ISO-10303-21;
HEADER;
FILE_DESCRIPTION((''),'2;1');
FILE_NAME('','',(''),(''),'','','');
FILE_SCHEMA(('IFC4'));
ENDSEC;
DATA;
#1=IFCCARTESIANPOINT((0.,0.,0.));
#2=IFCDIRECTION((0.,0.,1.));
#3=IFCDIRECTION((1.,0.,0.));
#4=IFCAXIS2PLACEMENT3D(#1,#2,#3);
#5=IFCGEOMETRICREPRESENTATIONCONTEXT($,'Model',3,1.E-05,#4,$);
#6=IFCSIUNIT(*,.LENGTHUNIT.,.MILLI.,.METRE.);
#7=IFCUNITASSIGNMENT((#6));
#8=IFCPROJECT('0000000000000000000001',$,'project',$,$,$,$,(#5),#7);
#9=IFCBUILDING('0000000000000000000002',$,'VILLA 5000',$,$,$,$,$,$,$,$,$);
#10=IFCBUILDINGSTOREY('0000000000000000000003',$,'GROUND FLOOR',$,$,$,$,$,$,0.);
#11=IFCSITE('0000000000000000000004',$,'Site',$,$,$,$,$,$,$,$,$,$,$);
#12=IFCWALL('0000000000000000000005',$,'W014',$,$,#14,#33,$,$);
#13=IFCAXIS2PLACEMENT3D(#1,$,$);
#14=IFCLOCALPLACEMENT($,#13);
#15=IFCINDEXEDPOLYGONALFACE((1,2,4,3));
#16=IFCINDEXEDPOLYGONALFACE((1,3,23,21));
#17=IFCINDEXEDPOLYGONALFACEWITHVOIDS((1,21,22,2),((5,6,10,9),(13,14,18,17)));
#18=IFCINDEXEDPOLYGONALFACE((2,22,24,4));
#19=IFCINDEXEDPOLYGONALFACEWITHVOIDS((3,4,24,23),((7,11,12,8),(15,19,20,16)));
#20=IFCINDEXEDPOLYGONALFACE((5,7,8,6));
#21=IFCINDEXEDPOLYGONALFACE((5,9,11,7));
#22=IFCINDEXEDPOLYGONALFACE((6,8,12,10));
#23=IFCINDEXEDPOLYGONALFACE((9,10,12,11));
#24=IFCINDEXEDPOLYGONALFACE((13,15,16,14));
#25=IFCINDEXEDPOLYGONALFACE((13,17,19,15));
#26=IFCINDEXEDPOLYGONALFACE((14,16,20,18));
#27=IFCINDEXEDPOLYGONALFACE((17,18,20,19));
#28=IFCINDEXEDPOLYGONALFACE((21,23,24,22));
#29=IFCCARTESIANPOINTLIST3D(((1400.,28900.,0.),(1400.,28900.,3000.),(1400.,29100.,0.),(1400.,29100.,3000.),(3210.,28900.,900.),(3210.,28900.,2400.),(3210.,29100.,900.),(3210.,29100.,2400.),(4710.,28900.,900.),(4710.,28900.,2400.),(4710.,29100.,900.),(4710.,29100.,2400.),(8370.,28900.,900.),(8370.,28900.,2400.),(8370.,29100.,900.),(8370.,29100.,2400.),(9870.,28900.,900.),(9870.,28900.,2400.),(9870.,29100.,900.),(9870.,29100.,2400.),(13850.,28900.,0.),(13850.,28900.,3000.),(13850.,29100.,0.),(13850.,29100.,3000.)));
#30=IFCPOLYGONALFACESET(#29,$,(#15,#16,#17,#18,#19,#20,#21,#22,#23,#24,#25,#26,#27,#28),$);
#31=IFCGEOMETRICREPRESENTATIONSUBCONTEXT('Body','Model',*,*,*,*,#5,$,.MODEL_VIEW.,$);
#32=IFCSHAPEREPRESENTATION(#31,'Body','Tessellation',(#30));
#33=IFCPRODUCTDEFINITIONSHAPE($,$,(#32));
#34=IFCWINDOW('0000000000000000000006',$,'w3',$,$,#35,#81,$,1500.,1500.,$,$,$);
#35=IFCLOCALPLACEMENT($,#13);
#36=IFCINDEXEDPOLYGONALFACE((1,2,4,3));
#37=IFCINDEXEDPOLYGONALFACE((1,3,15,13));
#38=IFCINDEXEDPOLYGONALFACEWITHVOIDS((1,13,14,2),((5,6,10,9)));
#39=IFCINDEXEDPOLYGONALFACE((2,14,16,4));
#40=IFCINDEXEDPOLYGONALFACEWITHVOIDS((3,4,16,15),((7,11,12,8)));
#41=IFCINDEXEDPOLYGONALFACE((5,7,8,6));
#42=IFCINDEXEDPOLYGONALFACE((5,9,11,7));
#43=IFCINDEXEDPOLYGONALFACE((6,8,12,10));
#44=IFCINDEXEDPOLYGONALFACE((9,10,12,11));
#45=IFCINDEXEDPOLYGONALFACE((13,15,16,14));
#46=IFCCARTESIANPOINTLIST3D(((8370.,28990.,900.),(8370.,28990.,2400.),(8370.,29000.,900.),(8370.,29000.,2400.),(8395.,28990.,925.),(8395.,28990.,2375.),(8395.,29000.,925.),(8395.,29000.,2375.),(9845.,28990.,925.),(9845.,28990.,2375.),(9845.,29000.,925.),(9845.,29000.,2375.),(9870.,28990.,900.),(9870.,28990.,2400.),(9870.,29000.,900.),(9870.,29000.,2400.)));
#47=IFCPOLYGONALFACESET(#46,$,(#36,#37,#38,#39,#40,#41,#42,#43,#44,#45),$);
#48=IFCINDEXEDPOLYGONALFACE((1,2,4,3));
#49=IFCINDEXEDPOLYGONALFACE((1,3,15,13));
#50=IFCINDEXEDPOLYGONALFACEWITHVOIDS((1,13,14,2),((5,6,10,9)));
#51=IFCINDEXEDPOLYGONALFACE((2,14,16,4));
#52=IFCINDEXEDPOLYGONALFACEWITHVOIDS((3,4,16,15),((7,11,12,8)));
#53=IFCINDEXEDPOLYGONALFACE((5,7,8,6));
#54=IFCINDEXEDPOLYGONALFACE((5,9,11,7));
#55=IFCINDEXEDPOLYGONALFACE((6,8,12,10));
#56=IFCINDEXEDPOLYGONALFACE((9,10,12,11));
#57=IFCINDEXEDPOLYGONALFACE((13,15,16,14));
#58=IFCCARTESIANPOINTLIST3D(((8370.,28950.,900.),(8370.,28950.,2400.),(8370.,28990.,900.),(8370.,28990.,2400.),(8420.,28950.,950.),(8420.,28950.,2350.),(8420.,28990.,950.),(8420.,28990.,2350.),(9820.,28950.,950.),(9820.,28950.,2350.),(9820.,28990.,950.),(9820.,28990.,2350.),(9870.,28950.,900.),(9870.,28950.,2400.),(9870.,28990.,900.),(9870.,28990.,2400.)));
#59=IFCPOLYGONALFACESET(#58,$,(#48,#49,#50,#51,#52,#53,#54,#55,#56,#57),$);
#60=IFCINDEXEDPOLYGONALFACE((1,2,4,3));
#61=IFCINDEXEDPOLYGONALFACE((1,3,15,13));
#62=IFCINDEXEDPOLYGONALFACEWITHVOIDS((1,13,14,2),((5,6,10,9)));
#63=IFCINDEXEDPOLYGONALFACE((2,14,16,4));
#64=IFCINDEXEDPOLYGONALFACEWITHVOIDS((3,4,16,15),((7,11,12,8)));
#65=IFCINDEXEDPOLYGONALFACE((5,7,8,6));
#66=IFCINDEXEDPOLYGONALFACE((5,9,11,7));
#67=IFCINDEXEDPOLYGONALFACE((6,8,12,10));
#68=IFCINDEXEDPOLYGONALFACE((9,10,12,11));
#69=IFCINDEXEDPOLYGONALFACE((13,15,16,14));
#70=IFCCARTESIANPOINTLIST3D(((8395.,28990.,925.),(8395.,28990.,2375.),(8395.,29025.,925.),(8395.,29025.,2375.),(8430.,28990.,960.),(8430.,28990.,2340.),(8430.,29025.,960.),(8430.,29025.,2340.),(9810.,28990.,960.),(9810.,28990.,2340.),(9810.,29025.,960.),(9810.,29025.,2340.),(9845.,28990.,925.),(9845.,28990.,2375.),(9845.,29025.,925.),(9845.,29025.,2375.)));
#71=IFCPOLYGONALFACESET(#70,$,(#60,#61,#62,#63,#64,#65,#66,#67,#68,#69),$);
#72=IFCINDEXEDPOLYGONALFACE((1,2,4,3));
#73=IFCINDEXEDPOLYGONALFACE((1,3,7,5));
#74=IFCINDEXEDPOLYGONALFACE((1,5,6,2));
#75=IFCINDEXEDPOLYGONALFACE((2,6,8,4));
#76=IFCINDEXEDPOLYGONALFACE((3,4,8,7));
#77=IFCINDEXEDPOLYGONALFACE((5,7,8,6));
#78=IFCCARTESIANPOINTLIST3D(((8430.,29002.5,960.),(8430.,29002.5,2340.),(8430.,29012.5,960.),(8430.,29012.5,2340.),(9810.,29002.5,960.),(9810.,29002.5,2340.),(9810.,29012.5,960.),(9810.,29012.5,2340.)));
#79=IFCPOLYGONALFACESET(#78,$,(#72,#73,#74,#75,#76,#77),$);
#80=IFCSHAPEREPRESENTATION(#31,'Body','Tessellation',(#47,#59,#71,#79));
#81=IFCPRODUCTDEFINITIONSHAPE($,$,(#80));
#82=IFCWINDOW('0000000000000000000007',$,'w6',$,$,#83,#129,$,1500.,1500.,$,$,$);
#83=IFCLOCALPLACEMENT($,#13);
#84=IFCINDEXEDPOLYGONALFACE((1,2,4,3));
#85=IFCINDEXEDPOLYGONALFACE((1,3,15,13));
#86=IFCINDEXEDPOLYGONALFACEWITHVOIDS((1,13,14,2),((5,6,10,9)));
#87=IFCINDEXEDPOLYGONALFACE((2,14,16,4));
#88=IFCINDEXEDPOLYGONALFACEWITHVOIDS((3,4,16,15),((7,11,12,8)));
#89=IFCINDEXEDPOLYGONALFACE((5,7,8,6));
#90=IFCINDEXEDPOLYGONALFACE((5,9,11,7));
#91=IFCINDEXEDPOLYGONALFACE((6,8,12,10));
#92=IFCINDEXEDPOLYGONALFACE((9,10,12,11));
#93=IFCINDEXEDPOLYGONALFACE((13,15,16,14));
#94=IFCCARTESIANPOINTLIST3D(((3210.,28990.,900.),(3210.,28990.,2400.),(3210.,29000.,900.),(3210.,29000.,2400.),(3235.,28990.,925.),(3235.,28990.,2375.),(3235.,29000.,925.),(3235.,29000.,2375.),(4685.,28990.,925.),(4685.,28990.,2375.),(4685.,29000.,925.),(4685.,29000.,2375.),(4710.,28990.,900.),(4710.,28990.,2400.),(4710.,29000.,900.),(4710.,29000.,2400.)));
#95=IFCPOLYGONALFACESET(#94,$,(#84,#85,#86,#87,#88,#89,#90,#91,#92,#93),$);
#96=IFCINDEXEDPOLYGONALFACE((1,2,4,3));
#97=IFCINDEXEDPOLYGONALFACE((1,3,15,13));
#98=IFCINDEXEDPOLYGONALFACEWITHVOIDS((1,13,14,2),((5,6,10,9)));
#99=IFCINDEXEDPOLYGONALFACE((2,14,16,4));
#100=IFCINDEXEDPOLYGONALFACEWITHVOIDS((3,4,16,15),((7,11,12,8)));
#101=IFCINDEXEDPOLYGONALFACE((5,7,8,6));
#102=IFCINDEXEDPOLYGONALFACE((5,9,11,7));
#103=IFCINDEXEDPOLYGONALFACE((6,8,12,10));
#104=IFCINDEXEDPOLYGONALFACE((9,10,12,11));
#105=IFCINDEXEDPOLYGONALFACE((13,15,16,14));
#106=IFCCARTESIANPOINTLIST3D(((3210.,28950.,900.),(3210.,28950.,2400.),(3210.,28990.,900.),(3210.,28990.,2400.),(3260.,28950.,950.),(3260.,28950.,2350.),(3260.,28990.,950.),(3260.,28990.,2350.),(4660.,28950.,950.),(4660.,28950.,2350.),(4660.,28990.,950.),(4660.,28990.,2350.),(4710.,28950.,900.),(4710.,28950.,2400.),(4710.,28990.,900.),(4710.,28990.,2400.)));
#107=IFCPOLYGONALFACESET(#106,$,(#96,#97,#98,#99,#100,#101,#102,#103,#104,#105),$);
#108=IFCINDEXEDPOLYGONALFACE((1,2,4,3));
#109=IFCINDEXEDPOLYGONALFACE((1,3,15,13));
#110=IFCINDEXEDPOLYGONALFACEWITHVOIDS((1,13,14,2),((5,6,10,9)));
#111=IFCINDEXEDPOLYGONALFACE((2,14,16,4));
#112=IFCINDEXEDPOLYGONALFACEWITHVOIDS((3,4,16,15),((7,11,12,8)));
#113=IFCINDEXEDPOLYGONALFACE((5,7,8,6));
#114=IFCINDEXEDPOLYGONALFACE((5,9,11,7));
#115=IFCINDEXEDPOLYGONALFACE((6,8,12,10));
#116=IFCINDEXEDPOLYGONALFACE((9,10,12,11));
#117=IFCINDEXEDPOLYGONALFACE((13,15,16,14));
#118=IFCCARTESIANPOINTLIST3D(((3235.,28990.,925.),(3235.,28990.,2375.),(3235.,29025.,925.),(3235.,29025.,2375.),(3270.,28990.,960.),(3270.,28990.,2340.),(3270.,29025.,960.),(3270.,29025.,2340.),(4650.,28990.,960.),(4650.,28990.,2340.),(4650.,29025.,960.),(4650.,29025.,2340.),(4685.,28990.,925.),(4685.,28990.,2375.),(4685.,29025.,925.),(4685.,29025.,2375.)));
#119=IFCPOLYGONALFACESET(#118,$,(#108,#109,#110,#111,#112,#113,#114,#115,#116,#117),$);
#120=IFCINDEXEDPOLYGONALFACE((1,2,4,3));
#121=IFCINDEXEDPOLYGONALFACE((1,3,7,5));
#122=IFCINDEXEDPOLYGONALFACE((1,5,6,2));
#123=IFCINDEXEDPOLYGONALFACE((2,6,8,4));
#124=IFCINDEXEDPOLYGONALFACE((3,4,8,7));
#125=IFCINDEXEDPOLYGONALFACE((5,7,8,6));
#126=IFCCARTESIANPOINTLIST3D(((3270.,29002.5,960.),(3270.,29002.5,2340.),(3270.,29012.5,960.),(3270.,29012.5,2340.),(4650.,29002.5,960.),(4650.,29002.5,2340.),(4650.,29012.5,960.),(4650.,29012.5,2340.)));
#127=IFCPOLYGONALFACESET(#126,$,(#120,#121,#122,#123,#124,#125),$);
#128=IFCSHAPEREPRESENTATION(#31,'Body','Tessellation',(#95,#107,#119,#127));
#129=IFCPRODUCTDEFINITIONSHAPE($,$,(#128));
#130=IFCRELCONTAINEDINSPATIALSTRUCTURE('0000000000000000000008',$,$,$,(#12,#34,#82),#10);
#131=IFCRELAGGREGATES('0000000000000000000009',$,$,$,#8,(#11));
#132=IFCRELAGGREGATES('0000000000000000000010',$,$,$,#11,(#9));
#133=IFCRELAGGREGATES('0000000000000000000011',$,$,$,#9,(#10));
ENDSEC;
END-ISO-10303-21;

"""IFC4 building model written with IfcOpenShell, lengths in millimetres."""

from ifc_helpers import new_model, si_unit, frame, origin_with_axes, place, context, subcontext, project, spatial, line, indexed_curve, outline, extrude, element, fill, save


model = new_model("IFC4")

# Units and contexts
model_context = context("Model", 3, precision=1e-05, world=origin_with_axes())
body_context = subcontext(model_context, "Body", "Model", "MODEL_VIEW")
ifc_project = project(units=[si_unit("LENGTHUNIT", "METRE", prefix="MILLI")], contexts=[model_context])

# Site, building, storey
site = spatial("IfcSite", under=ifc_project, Name="Site")
building = spatial("IfcBuilding", under=site, Name="VILLA 5000")
storey = spatial("IfcBuildingStorey", under=building, Name="GROUND FLOOR", Elevation=0.0)

# Wall, openings, windows
wall_1_placement = place(None, frame((1400.0, 29000.0, 0.0), z_axis=(0.0, 0.0, 1.0), x_axis=(1.0, 0.0, 0.0)))
wall_1 = element("IfcWall", 1, at=wall_1_placement, inside=storey, Name="W014", context=body_context, shape_type="SweptSolid", body=[
    extrude(outline(indexed_curve([(0.0, 0.0), (0.0, 200.0), (12450.0, 200.0), (12450.0, 0.0), (0.0, 0.0)], self_intersect=False)), frame((0.0, -100.0, 0.0), z_axis=(0.0, 0.0, 1.0), x_axis=(1.0, 0.0, 0.0)), (0.0, 0.0, 1.0), 3000.0),
])
opening_1_placement = place(wall_1_placement, frame((6970.0, 0.0, 900.0), z_axis=(0.0, 0.0, 1.0), x_axis=(1.0, 0.0, 0.0)))
opening_1 = element("IfcOpeningElement", 2, at=opening_1_placement, cuts=wall_1, context=body_context, shape_type="SweptSolid", body=[
    extrude(outline(indexed_curve([(0.0, 0.0), (0.0, 300.0), (1500.0, 300.0), (1500.0, 0.0), (0.0, 0.0)], self_intersect=False)), frame((0.0, -150.0, 0.0), z_axis=(0.0, 0.0, 1.0), x_axis=(1.0, 0.0, 0.0)), (0.0, 0.0, 1.0), 1500.0),
])
opening_2_placement = place(wall_1_placement, frame((1810.0, 0.0, 900.0), z_axis=(0.0, 0.0, 1.0), x_axis=(1.0, 0.0, 0.0)))
opening_2 = element("IfcOpeningElement", 3, at=opening_2_placement, cuts=wall_1, context=body_context, shape_type="SweptSolid", body=[
    extrude(outline(indexed_curve([(0.0, 0.0), (0.0, 300.0), (1500.0, 300.0), (1500.0, 0.0), (0.0, 0.0)], self_intersect=False)), frame((0.0, -150.0, 0.0), z_axis=(0.0, 0.0, 1.0), x_axis=(1.0, 0.0, 0.0)), (0.0, 0.0, 1.0), 1500.0),
])
window_1_placement = place(None, frame((8370.0, 28900.0, 900.0), z_axis=(0.0, 0.0, 1.0), x_axis=(1.0, 0.0, 0.0)))
window_1 = element("IfcWindow", 4, at=window_1_placement, inside=storey, Name="w3", OverallHeight=1500.0, OverallWidth=1500.0, context=body_context, shape_type="SweptSolid", body=[
    extrude(outline(indexed_curve([(0.0, 0.0), (1500.0, 0.0), (1500.0, 1500.0), (0.0, 1500.0)], segments=[line(1, 2, 3, 4, 1)]), holes=[indexed_curve([(25.0, 25.0), (1475.0, 25.0), (1475.0, 1475.0), (25.0, 1475.0)], segments=[line(1, 2, 3, 4, 1)])]), frame((0.0, 90.0, 0.0), z_axis=(0.0, -1.0, 0.0), x_axis=(1.0, 0.0, 0.0)), (0.0, 0.0, -1.0), 10.0),
    extrude(outline(indexed_curve([(0.0, 0.0), (1500.0, 0.0), (1500.0, 1500.0), (0.0, 1500.0)], segments=[line(1, 2, 3, 4, 1)]), holes=[indexed_curve([(50.0, 50.0), (1450.0, 50.0), (1450.0, 1450.0), (50.0, 1450.0)], segments=[line(1, 2, 3, 4, 1)])]), frame((0.0, 50.0, 0.0), z_axis=(0.0, -1.0, 0.0), x_axis=(1.0, 0.0, 0.0)), (0.0, 0.0, -1.0), 40.0),
    extrude(outline(indexed_curve([(0.0, 0.0), (1450.0, 0.0), (1450.0, 1450.0), (0.0, 1450.0)], segments=[line(1, 2, 3, 4, 1)]), holes=[indexed_curve([(35.0, 35.0), (1415.0, 35.0), (1415.0, 1415.0), (35.0, 1415.0)], segments=[line(1, 2, 3, 4, 1)])]), frame((25.0, 90.0, 25.0), z_axis=(0.0, -1.0, 0.0), x_axis=(1.0, 0.0, 0.0)), (0.0, 0.0, -1.0), 35.0),
    extrude(outline(indexed_curve([(35.0, 35.0), (1415.0, 35.0), (1415.0, 1415.0), (35.0, 1415.0)], segments=[line(1, 2, 3, 4, 1)])), frame((25.0, 102.5, 25.0), z_axis=(0.0, -1.0, 0.0), x_axis=(1.0, 0.0, 0.0)), (0.0, 0.0, -1.0), 10.0),
])
fill(opening_1, window_1)
window_2_placement = place(None, frame((3210.0, 28900.0, 900.0), z_axis=(0.0, 0.0, 1.0), x_axis=(1.0, 0.0, 0.0)))
window_2 = element("IfcWindow", 5, at=window_2_placement, inside=storey, Name="w6", OverallHeight=1500.0, OverallWidth=1500.0, context=body_context, shape_type="SweptSolid", body=[
    extrude(outline(indexed_curve([(0.0, 0.0), (1500.0, 0.0), (1500.0, 1500.0), (0.0, 1500.0)], segments=[line(1, 2, 3, 4, 1)]), holes=[indexed_curve([(25.0, 25.0), (1475.0, 25.0), (1475.0, 1475.0), (25.0, 1475.0)], segments=[line(1, 2, 3, 4, 1)])]), frame((0.0, 90.0, 0.0), z_axis=(0.0, -1.0, 0.0), x_axis=(1.0, 0.0, 0.0)), (0.0, 0.0, -1.0), 10.0),
    extrude(outline(indexed_curve([(0.0, 0.0), (1500.0, 0.0), (1500.0, 1500.0), (0.0, 1500.0)], segments=[line(1, 2, 3, 4, 1)]), holes=[indexed_curve([(50.0, 50.0), (1450.0, 50.0), (1450.0, 1450.0), (50.0, 1450.0)], segments=[line(1, 2, 3, 4, 1)])]), frame((0.0, 50.0, 0.0), z_axis=(0.0, -1.0, 0.0), x_axis=(1.0, 0.0, 0.0)), (0.0, 0.0, -1.0), 40.0),
    extrude(outline(indexed_curve([(0.0, 0.0), (1450.0, 0.0), (1450.0, 1450.0), (0.0, 1450.0)], segments=[line(1, 2, 3, 4, 1)]), holes=[indexed_curve([(35.0, 35.0), (1415.0, 35.0), (1415.0, 1415.0), (35.0, 1415.0)], segments=[line(1, 2, 3, 4, 1)])]), frame((25.0, 90.0, 25.0), z_axis=(0.0, -1.0, 0.0), x_axis=(1.0, 0.0, 0.0)), (0.0, 0.0, -1.0), 35.0),
    extrude(outline(indexed_curve([(35.0, 35.0), (1415.0, 35.0), (1415.0, 1415.0), (35.0, 1415.0)], segments=[line(1, 2, 3, 4, 1)])), frame((25.0, 102.5, 25.0), z_axis=(0.0, -1.0, 0.0), x_axis=(1.0, 0.0, 0.0)), (0.0, 0.0, -1.0), 10.0),
])
fill(opening_2, window_2)

save(model, "model.ifc")
